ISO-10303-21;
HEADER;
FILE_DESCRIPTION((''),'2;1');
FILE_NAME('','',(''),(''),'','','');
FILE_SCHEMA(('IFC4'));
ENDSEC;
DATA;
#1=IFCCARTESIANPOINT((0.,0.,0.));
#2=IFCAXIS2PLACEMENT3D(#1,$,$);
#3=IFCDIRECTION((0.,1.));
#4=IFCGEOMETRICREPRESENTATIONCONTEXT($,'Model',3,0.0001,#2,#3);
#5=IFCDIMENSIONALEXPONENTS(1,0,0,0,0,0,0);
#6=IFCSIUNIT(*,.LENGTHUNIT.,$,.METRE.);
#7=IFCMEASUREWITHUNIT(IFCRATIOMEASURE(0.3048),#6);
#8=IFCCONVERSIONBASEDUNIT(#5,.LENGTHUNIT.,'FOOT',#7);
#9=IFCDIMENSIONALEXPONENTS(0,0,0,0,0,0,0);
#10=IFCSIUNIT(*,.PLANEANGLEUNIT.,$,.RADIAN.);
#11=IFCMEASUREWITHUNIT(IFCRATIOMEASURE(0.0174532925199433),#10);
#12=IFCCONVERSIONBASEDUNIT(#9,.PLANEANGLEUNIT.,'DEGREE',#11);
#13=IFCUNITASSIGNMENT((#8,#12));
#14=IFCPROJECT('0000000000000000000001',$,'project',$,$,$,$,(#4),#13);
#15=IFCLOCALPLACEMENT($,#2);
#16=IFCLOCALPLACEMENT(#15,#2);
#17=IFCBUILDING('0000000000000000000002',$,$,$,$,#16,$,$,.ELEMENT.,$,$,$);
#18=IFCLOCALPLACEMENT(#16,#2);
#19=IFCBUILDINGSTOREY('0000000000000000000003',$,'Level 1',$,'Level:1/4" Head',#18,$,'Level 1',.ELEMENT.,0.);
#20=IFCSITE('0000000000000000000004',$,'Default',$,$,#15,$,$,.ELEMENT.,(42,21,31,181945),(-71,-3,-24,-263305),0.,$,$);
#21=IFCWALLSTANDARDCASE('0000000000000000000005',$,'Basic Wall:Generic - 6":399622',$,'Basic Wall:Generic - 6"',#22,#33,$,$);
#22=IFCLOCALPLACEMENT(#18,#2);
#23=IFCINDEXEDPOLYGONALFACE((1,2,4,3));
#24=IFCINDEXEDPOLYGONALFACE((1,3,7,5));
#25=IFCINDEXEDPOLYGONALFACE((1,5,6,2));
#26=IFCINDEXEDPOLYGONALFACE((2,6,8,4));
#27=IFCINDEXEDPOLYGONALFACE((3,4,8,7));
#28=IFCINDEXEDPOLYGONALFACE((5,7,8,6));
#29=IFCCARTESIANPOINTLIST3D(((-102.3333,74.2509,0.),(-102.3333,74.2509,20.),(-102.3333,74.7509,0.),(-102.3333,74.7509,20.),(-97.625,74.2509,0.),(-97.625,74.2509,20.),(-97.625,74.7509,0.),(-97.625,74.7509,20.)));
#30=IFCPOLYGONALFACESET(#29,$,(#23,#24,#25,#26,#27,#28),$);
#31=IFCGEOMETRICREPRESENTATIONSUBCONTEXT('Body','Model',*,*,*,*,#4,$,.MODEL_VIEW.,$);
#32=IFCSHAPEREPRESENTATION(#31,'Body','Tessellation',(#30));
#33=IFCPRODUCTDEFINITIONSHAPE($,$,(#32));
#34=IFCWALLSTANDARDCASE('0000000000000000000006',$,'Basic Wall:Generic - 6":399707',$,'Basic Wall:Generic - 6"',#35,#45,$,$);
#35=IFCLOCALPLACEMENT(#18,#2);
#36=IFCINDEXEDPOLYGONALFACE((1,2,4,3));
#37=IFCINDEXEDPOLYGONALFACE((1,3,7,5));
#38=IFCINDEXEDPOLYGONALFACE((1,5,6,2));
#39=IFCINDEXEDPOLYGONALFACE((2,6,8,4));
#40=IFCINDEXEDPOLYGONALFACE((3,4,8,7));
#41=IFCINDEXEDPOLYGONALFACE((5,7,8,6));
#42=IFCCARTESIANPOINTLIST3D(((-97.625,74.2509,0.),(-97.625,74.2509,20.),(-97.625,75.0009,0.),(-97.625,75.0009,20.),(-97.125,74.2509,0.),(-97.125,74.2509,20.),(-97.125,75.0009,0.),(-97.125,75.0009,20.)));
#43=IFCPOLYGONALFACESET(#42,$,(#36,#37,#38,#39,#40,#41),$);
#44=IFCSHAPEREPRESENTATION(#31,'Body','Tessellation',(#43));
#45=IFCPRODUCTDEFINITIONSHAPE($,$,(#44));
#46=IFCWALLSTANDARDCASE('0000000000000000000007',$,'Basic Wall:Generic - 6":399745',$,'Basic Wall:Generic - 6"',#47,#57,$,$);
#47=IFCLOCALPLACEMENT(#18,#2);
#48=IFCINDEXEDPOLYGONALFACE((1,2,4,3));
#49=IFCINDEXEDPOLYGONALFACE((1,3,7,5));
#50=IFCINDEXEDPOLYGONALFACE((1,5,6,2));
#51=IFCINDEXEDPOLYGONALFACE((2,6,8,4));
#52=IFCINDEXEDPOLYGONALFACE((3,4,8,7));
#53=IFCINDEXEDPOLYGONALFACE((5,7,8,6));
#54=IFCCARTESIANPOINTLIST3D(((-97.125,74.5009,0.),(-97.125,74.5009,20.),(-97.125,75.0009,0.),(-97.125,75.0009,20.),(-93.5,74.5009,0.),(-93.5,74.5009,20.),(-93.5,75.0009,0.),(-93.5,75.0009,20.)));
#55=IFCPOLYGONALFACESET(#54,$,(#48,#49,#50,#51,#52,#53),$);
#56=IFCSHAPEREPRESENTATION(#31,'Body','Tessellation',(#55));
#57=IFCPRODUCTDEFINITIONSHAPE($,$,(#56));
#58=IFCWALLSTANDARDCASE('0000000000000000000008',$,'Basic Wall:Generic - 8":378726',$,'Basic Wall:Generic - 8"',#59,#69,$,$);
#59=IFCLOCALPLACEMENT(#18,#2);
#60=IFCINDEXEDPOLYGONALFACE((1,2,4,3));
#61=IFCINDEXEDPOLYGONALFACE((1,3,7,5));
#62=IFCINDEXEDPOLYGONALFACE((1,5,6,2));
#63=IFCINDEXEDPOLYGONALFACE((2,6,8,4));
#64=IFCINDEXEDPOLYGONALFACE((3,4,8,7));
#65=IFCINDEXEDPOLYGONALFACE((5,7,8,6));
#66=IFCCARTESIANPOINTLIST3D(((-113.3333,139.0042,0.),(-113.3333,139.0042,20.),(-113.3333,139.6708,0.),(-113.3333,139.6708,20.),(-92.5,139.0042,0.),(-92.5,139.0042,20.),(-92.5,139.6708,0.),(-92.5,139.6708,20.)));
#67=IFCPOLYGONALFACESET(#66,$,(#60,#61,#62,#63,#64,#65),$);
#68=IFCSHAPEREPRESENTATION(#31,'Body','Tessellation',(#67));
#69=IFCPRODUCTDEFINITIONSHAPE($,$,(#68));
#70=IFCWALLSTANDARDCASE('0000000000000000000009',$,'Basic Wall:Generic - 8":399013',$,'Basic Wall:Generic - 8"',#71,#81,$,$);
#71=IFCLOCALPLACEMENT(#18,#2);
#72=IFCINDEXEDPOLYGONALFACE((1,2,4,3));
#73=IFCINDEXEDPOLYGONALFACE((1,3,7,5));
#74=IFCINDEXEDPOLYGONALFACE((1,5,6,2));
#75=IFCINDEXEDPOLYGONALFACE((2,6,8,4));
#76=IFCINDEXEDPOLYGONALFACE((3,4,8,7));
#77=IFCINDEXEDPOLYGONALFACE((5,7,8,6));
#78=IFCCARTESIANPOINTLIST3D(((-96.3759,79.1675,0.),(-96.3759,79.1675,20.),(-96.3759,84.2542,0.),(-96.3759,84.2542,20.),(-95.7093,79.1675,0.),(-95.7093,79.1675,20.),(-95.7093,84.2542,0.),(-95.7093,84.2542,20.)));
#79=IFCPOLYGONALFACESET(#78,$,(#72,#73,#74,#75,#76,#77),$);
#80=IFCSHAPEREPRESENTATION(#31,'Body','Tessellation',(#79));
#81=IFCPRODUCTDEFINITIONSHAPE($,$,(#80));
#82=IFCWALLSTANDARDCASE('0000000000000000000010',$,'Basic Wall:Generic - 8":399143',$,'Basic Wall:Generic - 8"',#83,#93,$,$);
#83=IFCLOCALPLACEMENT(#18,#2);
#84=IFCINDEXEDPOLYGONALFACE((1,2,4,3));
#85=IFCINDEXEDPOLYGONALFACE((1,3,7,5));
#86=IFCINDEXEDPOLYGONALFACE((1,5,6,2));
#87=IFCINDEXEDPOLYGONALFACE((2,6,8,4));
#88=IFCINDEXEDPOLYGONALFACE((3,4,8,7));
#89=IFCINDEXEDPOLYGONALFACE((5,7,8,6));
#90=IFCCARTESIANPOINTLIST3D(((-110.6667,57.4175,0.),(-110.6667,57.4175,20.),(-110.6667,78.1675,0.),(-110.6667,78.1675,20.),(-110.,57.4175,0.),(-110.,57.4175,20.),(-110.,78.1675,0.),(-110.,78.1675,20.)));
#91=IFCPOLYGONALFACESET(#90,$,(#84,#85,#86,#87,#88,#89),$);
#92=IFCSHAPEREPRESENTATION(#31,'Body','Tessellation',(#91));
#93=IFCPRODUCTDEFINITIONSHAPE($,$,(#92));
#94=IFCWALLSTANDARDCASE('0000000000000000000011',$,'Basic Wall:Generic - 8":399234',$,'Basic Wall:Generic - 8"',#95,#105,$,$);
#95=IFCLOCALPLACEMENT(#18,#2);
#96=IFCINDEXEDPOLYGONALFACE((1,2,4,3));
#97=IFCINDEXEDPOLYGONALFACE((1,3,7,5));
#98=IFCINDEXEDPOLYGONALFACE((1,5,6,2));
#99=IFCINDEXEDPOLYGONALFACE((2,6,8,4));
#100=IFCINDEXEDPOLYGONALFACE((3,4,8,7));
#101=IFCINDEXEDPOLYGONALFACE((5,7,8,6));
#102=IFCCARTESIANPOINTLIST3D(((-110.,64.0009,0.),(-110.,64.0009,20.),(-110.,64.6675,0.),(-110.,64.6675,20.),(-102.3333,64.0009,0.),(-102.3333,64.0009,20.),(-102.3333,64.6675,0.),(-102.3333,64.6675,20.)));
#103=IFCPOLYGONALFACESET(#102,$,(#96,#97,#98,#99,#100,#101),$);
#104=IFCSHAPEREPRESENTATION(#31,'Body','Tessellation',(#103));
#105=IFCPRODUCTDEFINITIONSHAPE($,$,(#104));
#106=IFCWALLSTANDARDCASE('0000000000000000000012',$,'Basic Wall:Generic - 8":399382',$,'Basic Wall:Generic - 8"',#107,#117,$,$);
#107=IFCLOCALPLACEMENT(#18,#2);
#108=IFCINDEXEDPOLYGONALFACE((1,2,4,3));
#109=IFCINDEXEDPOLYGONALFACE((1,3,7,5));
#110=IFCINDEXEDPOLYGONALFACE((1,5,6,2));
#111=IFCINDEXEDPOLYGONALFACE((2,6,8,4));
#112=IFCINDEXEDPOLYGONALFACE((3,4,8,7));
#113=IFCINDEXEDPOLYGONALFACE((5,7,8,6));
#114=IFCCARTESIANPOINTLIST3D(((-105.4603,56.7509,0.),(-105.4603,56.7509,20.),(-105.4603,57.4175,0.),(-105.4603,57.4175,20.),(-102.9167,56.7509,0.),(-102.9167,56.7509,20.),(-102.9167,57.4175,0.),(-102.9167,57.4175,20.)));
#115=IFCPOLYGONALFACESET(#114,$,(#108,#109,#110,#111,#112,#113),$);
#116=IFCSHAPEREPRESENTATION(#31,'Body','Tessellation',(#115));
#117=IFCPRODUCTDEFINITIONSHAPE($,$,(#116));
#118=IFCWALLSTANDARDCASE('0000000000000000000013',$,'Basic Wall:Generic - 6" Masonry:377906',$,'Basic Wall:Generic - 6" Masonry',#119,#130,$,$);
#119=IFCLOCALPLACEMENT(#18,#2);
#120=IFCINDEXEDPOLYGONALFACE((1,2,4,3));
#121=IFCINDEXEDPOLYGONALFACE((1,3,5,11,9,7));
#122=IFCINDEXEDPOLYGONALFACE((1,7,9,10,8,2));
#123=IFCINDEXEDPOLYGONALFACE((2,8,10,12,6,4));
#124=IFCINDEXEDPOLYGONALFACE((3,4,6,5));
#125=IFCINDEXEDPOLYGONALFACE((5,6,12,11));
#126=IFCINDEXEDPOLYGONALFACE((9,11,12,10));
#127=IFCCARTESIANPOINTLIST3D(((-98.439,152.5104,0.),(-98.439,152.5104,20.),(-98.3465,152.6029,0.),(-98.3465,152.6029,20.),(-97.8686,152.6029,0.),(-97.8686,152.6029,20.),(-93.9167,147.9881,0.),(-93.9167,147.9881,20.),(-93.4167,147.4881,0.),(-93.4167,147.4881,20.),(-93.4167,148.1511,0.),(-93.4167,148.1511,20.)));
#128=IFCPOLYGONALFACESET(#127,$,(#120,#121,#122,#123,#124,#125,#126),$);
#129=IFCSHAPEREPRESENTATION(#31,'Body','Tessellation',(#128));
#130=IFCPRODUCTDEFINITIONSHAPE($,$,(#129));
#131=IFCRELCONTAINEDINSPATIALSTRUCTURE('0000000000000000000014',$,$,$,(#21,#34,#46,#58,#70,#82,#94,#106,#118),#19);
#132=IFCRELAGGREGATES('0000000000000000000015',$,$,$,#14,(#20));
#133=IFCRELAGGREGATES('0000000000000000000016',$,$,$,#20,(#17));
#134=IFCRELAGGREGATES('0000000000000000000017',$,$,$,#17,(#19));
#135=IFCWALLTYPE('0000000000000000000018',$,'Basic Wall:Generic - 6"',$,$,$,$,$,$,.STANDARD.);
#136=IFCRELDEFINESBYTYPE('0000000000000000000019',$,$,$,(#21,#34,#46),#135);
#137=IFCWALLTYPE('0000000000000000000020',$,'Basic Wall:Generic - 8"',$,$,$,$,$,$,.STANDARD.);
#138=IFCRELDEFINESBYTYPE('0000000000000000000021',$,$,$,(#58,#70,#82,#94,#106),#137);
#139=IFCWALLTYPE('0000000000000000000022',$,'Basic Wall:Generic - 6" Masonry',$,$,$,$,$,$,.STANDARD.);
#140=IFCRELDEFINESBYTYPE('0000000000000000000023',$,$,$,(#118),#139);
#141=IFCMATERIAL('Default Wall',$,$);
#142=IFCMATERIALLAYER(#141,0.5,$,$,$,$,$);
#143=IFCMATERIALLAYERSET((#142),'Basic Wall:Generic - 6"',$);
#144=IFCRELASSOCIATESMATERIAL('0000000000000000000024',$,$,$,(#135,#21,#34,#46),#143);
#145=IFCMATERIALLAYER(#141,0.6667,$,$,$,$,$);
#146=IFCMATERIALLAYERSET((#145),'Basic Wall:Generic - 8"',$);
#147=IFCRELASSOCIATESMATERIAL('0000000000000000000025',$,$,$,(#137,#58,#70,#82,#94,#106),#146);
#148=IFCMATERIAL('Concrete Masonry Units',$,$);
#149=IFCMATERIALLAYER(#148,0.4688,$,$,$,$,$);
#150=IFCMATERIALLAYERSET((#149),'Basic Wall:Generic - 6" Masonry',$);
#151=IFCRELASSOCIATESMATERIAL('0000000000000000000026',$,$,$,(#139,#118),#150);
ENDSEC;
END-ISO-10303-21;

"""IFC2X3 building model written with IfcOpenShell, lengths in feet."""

from ifc_helpers import new_model, entity, si_unit, converted_unit, direction, frame, frame_2d, origin, place, context, subcontext, project, spatial, polyline, rectangle, outline, extrude, material, layer, layer_set, layer_usage, type_object, element, save


model = new_model("IFC2X3")

# Units and contexts
model_context = context("Model", 3, precision=0.0001, world=origin(), true_north=direction((0.0, 1.0)))
body_context = subcontext(model_context, "Body", "Model", "MODEL_VIEW")
ifc_project = project(units=[converted_unit("LENGTHUNIT", "FOOT", entity("IfcRatioMeasure", 0.3048), si_unit("LENGTHUNIT", "METRE"), dimensions=[1, 0, 0, 0, 0, 0, 0]), converted_unit("PLANEANGLEUNIT", "DEGREE", entity("IfcRatioMeasure", 0.0174532925199433), si_unit("PLANEANGLEUNIT", "RADIAN"), dimensions=[0, 0, 0, 0, 0, 0, 0])], contexts=[model_context])

# Site, building, storey
site_placement = place(None, origin())
site = spatial("IfcSite", under=ifc_project, at=site_placement, Name="Default", CompositionType="ELEMENT", RefLatitude=(42, 21, 31, 181945), RefLongitude=(-71, -3, -24, -263305), RefElevation=0.0)
building_placement = place(site_placement, origin())
building = spatial("IfcBuilding", under=site, at=building_placement, CompositionType="ELEMENT")
storey_placement = place(building_placement, origin())
storey = spatial("IfcBuildingStorey", under=building, at=storey_placement, Name="Level 1", ObjectType="Level:1/4\" Head", LongName="Level 1", CompositionType="ELEMENT", Elevation=0.0)

# Walls
ifc_material_1 = material(Name="Default Wall")
ifc_layer_1 = layer(ifc_material_1, 0.5)
ifc_layer_set_1 = layer_set([ifc_layer_1], Name="Basic Wall:Generic - 6\"")
wall_type_1 = type_object("IfcWallType", Name="Basic Wall:Generic - 6\"", PredefinedType="STANDARD", material=ifc_layer_set_1)
ifc_layer_usage_1 = layer_usage(ifc_layer_set_1, "AXIS2", "NEGATIVE", 0.25)
wall_1_placement = place(storey_placement, frame((-102.3333, 74.5009, 0.0)))
element("IfcWallStandardCase", 1, at=wall_1_placement, inside=storey, type_object=wall_type_1, material=ifc_layer_usage_1, Name="Basic Wall:Generic - 6\":399622", ObjectType="Basic Wall:Generic - 6\"", context=body_context, shape_type="SweptSolid", body=[
    extrude(rectangle(XDim=4.7083, YDim=0.5, at=frame_2d((2.3542, 0.0), x_axis=(-1.0, 0.0))), origin(), (0.0, 0.0, 1.0), 20.0),
])
ifc_layer_usage_2 = layer_usage(ifc_layer_set_1, "AXIS2", "NEGATIVE", 0.25)
wall_2_placement = place(storey_placement, frame((-97.375, 74.2509, 0.0), z_axis=(0.0, 0.0, 1.0), x_axis=(0.0, 1.0, 0.0)))
element("IfcWallStandardCase", 2, at=wall_2_placement, inside=storey, type_object=wall_type_1, material=ifc_layer_usage_2, Name="Basic Wall:Generic - 6\":399707", ObjectType="Basic Wall:Generic - 6\"", context=body_context, shape_type="SweptSolid", body=[
    extrude(rectangle(XDim=0.75, YDim=0.5, at=frame_2d((0.375, 0.0), x_axis=(-1.0, 0.0))), origin(), (0.0, 0.0, 1.0), 20.0),
])
ifc_layer_usage_3 = layer_usage(ifc_layer_set_1, "AXIS2", "NEGATIVE", 0.25)
wall_3_placement = place(storey_placement, frame((-97.125, 74.7509, 0.0)))
element("IfcWallStandardCase", 3, at=wall_3_placement, inside=storey, type_object=wall_type_1, material=ifc_layer_usage_3, Name="Basic Wall:Generic - 6\":399745", ObjectType="Basic Wall:Generic - 6\"", context=body_context, shape_type="SweptSolid", body=[
    extrude(rectangle(XDim=3.625, YDim=0.5, at=frame_2d((1.8125, 0.0), x_axis=(-1.0, 0.0))), origin(), (0.0, 0.0, 1.0), 20.0),
])
ifc_layer_2 = layer(ifc_material_1, 0.6667)
ifc_layer_set_2 = layer_set([ifc_layer_2], Name="Basic Wall:Generic - 8\"")
ifc_layer_usage_4 = layer_usage(ifc_layer_set_2, "AXIS2", "NEGATIVE", 0.3333)
wall_type_2 = type_object("IfcWallType", Name="Basic Wall:Generic - 8\"", PredefinedType="STANDARD", material=ifc_layer_set_2)
wall_4_placement = place(storey_placement, frame((-92.5, 139.3375, 0.0), z_axis=(0.0, 0.0, 1.0), x_axis=(-1.0, 0.0, 0.0)))
element("IfcWallStandardCase", 4, at=wall_4_placement, inside=storey, type_object=wall_type_2, material=ifc_layer_usage_4, Name="Basic Wall:Generic - 8\":378726", ObjectType="Basic Wall:Generic - 8\"", context=body_context, shape_type="SweptSolid", body=[
    extrude(rectangle(XDim=20.8333, YDim=0.6667, at=frame_2d((10.4167, 0.0), x_axis=(-1.0, 0.0))), origin(), (0.0, 0.0, 1.0), 20.0),
])
ifc_layer_usage_5 = layer_usage(ifc_layer_set_2, "AXIS2", "NEGATIVE", 0.3333)
wall_5_placement = place(storey_placement, frame((-96.0426, 79.1675, 0.0), z_axis=(0.0, 0.0, 1.0), x_axis=(0.0, 1.0, 0.0)))
element("IfcWallStandardCase", 5, at=wall_5_placement, inside=storey, type_object=wall_type_2, material=ifc_layer_usage_5, Name="Basic Wall:Generic - 8\":399013", ObjectType="Basic Wall:Generic - 8\"", context=body_context, shape_type="SweptSolid", body=[
    extrude(rectangle(XDim=5.0866, YDim=0.6667, at=frame_2d((2.5433, 0.0), x_axis=(-1.0, 0.0))), origin(), (0.0, 0.0, 1.0), 20.0),
])
ifc_layer_usage_6 = layer_usage(ifc_layer_set_2, "AXIS2", "NEGATIVE", 0.3333)
wall_6_placement = place(storey_placement, frame((-110.3333, 78.1675, 0.0), z_axis=(0.0, 0.0, 1.0), x_axis=(0.0, -1.0, 0.0)))
element("IfcWallStandardCase", 6, at=wall_6_placement, inside=storey, type_object=wall_type_2, material=ifc_layer_usage_6, Name="Basic Wall:Generic - 8\":399143", ObjectType="Basic Wall:Generic - 8\"", context=body_context, shape_type="SweptSolid", body=[
    extrude(rectangle(XDim=20.75, YDim=0.6667, at=frame_2d((10.375, 0.0), x_axis=(-1.0, 0.0))), origin(), (0.0, 0.0, 1.0), 20.0),
])
ifc_layer_usage_7 = layer_usage(ifc_layer_set_2, "AXIS2", "NEGATIVE", 0.3333)
wall_7_placement = place(storey_placement, frame((-110.0, 64.3342, 0.0)))
element("IfcWallStandardCase", 7, at=wall_7_placement, inside=storey, type_object=wall_type_2, material=ifc_layer_usage_7, Name="Basic Wall:Generic - 8\":399234", ObjectType="Basic Wall:Generic - 8\"", context=body_context, shape_type="SweptSolid", body=[
    extrude(rectangle(XDim=7.6667, YDim=0.6667, at=frame_2d((3.8333, 0.0), x_axis=(-1.0, 0.0))), origin(), (0.0, 0.0, 1.0), 20.0),
])
ifc_layer_usage_8 = layer_usage(ifc_layer_set_2, "AXIS2", "NEGATIVE", 0.3333)
wall_8_placement = place(storey_placement, frame((-102.9167, 57.0842, 0.0), z_axis=(0.0, 0.0, 1.0), x_axis=(-1.0, 0.0, 0.0)))
element("IfcWallStandardCase", 8, at=wall_8_placement, inside=storey, type_object=wall_type_2, material=ifc_layer_usage_8, Name="Basic Wall:Generic - 8\":399382", ObjectType="Basic Wall:Generic - 8\"", context=body_context, shape_type="SweptSolid", body=[
    extrude(rectangle(XDim=2.5436, YDim=0.6667, at=frame_2d((1.2718, 0.0), x_axis=(-1.0, 0.0))), origin(), (0.0, 0.0, 1.0), 20.0),
])
ifc_material_2 = material(Name="Concrete Masonry Units")
ifc_layer_3 = layer(ifc_material_2, 0.4688)
ifc_layer_set_3 = layer_set([ifc_layer_3], Name="Basic Wall:Generic - 6\" Masonry")
ifc_layer_usage_9 = layer_usage(ifc_layer_set_3, "AXIS2", "NEGATIVE", 0.2344)
wall_type_3 = type_object("IfcWallType", Name="Basic Wall:Generic - 6\" Masonry", PredefinedType="STANDARD", material=ifc_layer_set_3)
wall_9_placement = place(storey_placement, frame((-98.2732, 152.6762, 0.0), z_axis=(0.0, 0.0, 1.0), x_axis=(0.707107, -0.707107, 0.0)))
element("IfcWallStandardCase", 9, at=wall_9_placement, inside=storey, type_object=wall_type_3, material=ifc_layer_usage_9, Name="Basic Wall:Generic - 6\" Masonry:377906", ObjectType="Basic Wall:Generic - 6\" Masonry", context=body_context, shape_type="SweptSolid", body=[
    extrude(outline(polyline([(7.1026, -0.2344), (6.6339, 0.2344), (0.3379, 0.2344), (0.0, -0.1036), (0.0, -0.2344), (6.3955, -0.2344), (7.1026, -0.2344)])), origin(), (0.0, 0.0, 1.0), 20.0),
])

save(model, "model.ifc")
